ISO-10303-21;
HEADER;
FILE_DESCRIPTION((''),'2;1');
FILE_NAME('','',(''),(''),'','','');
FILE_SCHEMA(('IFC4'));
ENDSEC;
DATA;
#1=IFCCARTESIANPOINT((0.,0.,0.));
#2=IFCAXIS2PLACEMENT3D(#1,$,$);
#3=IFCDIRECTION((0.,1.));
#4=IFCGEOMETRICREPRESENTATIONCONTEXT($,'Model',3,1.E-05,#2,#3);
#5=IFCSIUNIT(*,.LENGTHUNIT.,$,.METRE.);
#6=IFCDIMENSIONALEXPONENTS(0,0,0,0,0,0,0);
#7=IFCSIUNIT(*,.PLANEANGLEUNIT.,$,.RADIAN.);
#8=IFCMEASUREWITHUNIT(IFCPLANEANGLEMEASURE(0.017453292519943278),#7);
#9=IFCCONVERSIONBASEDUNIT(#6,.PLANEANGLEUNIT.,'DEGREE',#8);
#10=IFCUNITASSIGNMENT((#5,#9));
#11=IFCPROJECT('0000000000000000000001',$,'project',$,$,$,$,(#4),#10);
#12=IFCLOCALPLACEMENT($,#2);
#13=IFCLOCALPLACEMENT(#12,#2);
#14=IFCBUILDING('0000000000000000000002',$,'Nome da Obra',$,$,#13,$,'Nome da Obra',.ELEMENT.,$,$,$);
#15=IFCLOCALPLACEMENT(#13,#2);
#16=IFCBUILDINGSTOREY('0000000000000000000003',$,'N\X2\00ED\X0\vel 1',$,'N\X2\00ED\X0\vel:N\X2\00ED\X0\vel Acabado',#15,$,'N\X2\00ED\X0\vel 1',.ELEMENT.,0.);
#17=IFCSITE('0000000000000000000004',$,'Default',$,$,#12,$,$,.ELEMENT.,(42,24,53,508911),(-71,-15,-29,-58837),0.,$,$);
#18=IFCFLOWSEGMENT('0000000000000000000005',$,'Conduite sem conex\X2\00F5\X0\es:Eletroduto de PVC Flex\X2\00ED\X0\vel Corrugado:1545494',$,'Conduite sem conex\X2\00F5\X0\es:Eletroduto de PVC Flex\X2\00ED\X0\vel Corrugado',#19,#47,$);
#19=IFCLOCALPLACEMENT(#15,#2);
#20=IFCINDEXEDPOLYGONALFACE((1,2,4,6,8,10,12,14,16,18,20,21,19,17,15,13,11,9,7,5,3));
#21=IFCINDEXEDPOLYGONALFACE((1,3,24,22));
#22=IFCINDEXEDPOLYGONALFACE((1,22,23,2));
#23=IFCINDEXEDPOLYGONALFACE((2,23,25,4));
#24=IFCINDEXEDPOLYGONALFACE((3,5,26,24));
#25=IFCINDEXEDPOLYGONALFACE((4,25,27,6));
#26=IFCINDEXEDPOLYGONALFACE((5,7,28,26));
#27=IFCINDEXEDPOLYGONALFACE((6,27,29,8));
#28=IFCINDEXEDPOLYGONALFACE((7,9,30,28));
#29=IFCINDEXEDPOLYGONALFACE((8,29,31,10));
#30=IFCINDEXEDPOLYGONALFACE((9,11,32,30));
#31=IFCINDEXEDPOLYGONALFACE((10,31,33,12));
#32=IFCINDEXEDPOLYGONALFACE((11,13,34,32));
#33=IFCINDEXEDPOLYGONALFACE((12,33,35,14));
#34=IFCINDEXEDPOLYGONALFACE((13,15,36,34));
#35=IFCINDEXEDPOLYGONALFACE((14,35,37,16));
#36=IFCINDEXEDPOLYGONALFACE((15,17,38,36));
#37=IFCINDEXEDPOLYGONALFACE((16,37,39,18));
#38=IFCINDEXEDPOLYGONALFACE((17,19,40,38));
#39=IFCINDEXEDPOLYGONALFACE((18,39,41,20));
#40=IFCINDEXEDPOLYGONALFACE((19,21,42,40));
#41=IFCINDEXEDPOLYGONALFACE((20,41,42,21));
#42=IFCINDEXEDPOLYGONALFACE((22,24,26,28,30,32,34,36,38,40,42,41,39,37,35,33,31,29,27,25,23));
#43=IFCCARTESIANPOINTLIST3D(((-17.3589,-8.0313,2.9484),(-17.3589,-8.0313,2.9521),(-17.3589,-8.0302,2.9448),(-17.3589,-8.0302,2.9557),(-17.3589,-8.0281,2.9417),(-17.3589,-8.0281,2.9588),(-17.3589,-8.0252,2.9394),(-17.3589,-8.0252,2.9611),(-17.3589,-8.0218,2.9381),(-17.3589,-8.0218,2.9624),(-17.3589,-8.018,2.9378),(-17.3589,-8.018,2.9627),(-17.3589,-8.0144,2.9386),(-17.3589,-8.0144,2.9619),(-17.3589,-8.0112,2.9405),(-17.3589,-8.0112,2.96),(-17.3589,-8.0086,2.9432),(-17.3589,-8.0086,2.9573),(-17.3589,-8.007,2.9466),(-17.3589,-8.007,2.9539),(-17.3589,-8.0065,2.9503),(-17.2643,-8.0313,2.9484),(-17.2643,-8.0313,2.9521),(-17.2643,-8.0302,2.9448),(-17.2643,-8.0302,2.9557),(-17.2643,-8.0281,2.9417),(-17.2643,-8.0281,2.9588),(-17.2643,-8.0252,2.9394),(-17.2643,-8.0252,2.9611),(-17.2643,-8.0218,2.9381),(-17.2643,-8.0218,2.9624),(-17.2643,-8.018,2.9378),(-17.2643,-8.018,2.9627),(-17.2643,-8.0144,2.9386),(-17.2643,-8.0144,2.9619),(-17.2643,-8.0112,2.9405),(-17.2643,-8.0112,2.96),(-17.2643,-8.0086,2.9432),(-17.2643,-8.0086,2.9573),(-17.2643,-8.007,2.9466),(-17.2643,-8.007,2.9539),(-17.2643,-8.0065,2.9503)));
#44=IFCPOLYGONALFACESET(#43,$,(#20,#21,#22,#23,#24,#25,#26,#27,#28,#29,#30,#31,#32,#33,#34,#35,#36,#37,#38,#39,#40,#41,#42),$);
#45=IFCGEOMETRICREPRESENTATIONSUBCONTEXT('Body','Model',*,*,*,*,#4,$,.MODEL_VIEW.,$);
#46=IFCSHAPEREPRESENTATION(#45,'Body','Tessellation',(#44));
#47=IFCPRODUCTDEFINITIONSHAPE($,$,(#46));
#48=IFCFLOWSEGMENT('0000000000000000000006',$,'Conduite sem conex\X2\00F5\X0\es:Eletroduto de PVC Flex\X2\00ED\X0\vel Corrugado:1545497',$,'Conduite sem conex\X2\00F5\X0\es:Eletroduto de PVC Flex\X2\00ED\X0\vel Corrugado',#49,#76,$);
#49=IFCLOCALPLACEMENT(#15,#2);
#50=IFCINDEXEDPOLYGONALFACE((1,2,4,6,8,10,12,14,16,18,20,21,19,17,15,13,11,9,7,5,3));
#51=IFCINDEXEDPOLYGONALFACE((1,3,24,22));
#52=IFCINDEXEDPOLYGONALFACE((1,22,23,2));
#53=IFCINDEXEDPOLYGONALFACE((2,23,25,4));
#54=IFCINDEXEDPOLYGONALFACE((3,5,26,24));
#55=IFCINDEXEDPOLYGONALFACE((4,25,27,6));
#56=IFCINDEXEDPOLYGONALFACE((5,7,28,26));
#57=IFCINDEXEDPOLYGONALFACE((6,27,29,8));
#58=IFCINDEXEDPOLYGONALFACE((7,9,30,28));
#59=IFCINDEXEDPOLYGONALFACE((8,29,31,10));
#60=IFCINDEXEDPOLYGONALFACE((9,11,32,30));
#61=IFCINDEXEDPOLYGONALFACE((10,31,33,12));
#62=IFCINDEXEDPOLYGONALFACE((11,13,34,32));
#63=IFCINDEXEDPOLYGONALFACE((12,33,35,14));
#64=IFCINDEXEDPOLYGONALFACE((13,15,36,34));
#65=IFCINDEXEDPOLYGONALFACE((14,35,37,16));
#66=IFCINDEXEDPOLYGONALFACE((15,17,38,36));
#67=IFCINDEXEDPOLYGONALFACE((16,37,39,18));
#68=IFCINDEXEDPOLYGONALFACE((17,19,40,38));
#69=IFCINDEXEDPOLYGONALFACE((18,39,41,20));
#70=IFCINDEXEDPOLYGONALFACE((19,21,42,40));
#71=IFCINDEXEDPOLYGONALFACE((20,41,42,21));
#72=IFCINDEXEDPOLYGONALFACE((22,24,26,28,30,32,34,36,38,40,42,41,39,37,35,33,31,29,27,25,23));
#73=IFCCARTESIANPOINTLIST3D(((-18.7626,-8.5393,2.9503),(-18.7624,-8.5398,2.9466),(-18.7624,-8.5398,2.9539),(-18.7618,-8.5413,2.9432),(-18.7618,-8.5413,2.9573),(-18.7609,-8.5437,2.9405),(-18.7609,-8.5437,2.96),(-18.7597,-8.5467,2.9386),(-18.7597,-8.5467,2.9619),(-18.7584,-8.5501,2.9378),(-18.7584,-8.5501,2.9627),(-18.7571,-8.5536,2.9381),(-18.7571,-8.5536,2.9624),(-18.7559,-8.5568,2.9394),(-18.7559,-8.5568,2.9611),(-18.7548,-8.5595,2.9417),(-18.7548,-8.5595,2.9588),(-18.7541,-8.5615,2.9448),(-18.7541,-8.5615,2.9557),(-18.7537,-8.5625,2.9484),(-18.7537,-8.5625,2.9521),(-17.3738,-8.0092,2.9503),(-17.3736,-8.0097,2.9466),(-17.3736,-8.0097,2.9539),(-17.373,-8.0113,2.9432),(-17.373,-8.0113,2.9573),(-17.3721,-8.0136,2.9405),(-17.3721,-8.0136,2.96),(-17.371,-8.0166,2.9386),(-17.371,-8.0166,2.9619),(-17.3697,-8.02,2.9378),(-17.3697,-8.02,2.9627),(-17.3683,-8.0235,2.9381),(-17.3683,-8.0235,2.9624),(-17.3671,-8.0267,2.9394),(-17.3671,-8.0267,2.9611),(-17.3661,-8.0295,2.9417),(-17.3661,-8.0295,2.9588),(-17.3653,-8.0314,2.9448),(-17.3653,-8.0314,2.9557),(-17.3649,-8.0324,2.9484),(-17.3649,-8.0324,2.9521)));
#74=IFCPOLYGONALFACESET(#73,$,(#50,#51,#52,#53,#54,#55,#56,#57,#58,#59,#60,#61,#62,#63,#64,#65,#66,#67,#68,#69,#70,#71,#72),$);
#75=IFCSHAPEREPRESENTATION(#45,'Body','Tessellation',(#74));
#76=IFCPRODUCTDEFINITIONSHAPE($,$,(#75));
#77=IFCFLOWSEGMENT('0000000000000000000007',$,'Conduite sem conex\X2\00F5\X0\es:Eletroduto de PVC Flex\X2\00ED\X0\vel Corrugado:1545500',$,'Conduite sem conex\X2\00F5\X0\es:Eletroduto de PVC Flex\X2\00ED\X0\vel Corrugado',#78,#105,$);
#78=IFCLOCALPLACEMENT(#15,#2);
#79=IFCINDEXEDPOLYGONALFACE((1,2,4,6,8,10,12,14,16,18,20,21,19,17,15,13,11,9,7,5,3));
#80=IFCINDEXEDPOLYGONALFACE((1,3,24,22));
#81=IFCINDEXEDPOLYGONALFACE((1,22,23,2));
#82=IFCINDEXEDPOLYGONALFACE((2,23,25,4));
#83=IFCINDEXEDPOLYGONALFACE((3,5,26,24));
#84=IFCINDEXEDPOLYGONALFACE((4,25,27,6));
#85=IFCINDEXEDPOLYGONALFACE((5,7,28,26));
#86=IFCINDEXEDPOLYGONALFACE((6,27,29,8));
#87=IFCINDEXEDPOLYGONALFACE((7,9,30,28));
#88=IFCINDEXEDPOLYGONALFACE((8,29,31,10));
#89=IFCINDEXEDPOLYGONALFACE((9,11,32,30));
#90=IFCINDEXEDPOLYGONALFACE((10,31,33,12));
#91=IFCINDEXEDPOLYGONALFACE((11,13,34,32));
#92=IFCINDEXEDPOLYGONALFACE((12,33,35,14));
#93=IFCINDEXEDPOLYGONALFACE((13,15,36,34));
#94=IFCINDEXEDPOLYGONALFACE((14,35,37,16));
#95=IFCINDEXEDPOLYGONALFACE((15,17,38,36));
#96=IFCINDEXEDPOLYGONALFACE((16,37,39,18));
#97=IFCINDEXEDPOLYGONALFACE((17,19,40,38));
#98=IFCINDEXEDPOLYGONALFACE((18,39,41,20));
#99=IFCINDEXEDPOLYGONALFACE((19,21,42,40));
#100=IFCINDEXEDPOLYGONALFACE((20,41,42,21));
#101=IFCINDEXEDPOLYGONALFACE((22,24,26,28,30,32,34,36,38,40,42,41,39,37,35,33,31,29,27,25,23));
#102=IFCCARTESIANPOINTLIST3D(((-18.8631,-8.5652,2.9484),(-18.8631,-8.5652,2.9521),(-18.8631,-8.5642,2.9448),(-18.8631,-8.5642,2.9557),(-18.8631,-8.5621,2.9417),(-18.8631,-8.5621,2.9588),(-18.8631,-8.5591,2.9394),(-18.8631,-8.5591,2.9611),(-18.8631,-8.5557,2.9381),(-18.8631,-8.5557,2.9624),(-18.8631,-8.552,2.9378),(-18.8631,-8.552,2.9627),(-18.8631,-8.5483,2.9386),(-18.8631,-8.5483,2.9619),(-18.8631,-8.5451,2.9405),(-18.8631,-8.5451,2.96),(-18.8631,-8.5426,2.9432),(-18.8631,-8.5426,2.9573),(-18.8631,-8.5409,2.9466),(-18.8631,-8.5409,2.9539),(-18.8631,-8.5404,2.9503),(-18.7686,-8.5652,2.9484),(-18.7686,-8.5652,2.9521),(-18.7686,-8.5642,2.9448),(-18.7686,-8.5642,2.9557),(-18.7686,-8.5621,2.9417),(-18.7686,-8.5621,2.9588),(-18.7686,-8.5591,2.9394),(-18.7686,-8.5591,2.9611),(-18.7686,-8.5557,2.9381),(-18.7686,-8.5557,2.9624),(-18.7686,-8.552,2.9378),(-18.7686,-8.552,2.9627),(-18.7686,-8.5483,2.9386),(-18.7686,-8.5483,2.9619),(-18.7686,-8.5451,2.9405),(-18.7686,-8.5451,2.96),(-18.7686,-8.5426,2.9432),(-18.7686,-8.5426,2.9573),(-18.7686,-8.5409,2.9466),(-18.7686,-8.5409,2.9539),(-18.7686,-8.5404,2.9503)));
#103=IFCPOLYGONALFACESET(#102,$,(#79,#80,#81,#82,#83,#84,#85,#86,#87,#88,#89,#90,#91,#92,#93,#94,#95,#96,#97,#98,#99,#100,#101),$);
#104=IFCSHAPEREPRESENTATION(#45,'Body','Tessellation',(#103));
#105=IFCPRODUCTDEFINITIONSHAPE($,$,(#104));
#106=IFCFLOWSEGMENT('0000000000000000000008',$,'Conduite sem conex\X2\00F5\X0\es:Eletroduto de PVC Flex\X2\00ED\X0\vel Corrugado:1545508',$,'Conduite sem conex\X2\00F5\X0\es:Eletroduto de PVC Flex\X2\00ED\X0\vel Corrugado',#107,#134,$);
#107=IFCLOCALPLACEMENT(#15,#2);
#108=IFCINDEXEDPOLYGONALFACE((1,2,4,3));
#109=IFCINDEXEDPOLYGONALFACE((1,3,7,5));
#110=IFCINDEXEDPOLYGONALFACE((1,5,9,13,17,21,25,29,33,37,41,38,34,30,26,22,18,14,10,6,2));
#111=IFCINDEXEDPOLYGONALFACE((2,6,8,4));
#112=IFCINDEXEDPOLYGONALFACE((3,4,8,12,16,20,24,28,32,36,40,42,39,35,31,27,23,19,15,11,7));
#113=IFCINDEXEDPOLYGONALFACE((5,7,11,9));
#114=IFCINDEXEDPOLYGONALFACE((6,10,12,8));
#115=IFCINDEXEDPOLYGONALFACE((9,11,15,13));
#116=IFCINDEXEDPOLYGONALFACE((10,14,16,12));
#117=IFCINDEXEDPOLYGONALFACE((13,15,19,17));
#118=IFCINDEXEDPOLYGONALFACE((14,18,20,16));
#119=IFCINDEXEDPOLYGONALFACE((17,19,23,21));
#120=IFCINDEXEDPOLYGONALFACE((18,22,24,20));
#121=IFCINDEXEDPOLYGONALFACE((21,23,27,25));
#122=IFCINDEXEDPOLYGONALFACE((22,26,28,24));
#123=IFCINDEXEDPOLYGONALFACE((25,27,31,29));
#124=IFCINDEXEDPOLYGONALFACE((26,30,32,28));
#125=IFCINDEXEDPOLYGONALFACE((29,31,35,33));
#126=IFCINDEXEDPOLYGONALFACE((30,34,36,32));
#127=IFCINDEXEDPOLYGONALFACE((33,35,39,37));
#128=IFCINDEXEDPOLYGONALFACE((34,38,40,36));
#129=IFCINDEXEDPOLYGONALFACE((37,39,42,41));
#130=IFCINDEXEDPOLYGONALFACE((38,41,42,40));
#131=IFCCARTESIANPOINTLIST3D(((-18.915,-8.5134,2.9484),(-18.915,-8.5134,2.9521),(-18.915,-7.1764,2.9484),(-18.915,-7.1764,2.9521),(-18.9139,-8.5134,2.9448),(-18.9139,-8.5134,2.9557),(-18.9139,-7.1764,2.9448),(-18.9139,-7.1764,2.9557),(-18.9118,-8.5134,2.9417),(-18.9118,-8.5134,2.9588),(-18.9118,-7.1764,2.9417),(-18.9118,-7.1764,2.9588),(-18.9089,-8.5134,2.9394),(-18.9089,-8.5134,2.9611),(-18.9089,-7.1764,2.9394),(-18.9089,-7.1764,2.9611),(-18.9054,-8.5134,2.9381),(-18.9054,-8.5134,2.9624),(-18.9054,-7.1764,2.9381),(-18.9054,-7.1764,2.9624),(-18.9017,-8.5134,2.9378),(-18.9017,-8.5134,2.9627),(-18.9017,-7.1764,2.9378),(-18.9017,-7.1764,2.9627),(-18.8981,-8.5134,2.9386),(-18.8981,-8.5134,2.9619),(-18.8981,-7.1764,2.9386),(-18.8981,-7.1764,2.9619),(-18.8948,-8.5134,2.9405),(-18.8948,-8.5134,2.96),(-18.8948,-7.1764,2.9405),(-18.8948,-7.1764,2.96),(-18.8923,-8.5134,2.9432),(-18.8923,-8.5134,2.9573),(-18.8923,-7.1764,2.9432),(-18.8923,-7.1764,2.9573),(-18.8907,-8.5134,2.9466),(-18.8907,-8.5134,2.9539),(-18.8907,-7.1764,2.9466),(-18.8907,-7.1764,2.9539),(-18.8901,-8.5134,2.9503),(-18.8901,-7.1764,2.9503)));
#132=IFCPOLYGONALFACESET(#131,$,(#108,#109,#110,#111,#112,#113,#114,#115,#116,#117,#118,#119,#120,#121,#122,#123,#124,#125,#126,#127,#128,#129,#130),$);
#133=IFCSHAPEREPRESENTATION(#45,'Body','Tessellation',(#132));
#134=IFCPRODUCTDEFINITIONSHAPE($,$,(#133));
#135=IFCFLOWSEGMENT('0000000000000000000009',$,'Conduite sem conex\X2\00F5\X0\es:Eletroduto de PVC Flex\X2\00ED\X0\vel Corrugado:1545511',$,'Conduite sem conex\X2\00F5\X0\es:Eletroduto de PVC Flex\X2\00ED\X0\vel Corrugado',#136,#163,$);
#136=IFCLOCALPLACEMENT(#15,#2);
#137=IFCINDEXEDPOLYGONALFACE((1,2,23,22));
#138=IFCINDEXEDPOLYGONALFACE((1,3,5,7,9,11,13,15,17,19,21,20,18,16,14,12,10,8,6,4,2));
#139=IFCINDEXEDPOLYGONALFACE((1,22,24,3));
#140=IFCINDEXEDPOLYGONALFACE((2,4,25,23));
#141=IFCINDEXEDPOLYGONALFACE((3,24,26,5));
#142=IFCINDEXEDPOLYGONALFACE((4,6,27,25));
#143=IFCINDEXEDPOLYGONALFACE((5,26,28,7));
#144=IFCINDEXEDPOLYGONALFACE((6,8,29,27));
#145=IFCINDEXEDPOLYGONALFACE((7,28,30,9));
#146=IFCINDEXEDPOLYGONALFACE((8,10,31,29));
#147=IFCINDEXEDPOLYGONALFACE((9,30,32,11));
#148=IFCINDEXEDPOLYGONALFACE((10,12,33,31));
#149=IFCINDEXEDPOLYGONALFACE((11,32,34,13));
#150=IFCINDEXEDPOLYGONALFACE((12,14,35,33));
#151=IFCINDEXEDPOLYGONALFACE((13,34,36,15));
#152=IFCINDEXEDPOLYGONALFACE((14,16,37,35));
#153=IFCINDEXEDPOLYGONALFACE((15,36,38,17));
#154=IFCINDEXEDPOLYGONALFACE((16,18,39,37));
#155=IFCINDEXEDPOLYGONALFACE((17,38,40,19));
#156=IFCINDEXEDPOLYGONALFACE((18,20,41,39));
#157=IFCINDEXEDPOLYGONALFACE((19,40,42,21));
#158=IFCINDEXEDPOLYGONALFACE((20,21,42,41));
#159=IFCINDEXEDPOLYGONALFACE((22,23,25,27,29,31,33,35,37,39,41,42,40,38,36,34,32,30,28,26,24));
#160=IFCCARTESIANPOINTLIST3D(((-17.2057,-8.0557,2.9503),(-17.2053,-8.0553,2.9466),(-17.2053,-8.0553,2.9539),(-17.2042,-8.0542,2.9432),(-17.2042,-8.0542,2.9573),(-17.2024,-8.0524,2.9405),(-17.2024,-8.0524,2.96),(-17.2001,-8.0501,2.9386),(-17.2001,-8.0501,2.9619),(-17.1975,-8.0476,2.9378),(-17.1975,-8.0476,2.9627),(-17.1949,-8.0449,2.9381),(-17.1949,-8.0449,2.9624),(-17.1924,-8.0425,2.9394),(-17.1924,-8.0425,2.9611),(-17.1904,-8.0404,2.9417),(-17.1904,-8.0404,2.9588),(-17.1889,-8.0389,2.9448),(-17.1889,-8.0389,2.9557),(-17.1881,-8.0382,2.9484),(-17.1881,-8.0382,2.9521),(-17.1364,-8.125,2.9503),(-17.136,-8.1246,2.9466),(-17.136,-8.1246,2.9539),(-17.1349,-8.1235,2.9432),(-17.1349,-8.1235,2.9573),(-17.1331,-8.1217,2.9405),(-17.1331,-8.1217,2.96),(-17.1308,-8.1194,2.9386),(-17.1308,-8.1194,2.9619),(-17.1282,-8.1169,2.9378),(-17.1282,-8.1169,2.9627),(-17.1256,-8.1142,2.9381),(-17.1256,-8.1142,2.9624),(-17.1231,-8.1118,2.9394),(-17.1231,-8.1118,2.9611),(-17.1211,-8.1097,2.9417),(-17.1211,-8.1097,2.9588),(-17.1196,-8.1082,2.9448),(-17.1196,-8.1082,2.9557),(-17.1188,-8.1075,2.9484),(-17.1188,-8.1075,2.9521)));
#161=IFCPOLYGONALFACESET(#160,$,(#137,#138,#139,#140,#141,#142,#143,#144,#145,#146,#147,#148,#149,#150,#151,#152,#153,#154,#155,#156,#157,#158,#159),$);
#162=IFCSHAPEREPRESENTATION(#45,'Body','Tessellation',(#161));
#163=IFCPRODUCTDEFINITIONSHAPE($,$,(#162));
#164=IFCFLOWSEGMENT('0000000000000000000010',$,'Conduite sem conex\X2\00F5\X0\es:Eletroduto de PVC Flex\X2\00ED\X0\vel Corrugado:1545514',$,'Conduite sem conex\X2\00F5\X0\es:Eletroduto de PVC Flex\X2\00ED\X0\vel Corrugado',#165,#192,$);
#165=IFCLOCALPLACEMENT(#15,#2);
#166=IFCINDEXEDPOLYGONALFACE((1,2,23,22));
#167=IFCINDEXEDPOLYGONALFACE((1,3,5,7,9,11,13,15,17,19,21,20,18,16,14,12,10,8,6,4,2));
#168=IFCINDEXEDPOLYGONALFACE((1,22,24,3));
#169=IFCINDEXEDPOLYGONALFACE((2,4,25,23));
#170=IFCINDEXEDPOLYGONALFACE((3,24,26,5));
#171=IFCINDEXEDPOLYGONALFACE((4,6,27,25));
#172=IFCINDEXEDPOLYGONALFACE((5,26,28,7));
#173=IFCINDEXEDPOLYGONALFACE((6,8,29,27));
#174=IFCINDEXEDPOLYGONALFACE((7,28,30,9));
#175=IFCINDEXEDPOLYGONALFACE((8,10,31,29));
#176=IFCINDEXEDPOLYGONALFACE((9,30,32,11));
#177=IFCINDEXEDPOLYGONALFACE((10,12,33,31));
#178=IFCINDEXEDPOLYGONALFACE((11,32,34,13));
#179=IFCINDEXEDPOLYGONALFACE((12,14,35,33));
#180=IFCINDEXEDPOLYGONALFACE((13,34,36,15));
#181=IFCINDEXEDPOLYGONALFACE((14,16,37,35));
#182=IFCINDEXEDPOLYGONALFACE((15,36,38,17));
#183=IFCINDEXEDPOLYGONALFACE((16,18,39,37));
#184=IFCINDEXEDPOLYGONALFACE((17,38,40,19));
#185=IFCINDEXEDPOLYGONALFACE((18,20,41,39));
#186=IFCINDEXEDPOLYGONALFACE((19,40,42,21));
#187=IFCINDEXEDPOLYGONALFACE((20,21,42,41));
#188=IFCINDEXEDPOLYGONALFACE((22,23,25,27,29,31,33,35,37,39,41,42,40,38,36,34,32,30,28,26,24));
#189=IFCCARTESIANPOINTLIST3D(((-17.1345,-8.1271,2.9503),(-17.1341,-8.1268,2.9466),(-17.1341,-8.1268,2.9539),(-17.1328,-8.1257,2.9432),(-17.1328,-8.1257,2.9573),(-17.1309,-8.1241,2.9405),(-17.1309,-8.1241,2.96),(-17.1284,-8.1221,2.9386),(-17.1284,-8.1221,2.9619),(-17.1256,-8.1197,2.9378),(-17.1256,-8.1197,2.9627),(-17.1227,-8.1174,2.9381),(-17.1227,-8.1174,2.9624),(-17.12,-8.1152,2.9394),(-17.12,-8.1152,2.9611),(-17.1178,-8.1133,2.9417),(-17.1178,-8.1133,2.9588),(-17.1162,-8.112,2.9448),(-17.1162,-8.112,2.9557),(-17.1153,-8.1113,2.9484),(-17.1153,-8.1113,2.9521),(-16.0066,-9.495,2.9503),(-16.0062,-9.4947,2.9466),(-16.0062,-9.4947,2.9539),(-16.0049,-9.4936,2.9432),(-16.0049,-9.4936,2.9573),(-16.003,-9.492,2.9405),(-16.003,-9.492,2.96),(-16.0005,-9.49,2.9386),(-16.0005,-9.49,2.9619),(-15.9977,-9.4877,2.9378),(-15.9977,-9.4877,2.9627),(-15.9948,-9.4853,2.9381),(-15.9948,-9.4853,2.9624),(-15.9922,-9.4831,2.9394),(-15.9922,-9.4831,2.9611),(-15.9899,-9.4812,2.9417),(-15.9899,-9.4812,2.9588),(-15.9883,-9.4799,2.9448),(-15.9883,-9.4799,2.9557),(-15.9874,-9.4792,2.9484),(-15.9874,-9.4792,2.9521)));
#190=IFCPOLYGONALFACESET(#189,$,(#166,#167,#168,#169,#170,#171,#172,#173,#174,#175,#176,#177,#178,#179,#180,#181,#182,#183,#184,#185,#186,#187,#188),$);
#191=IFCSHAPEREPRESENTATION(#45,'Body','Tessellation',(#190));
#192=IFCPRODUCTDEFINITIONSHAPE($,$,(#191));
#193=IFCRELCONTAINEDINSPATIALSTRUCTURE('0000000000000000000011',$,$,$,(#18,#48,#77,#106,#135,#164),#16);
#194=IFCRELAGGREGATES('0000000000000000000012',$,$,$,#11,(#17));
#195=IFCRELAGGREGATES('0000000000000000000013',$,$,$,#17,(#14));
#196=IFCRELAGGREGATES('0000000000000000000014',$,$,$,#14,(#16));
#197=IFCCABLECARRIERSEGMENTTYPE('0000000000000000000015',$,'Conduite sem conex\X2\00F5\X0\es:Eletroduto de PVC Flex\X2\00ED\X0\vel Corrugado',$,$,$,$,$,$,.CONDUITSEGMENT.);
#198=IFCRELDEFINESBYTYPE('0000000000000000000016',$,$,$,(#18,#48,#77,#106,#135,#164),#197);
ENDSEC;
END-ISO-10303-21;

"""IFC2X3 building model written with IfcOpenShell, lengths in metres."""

from ifc_helpers import new_model, entity, si_unit, converted_unit, direction, frame, frame_2d, origin, origin_2d_with_axis, place, context, subcontext, project, spatial, circle, extrude, type_object, element, save


model = new_model("IFC2X3")

# Units and contexts
model_context = context("Model", 3, precision=1e-05, world=origin(), true_north=direction((0.0, 1.0)))
body_context = subcontext(model_context, "Body", "Model", "MODEL_VIEW")
ifc_project = project(units=[si_unit("LENGTHUNIT", "METRE"), converted_unit("PLANEANGLEUNIT", "DEGREE", entity("IfcPlaneAngleMeasure", 0.017453292519943278), si_unit("PLANEANGLEUNIT", "RADIAN"), dimensions=[0, 0, 0, 0, 0, 0, 0])], contexts=[model_context])

# Site, building, storey
site_placement = place(None, origin())
site = spatial("IfcSite", under=ifc_project, at=site_placement, Name="Default", CompositionType="ELEMENT", RefLatitude=(42, 24, 53, 508911), RefLongitude=(-71, -15, -29, -58837), RefElevation=0.0)
building_placement = place(site_placement, origin())
building = spatial("IfcBuilding", under=site, at=building_placement, Name="Nome da Obra", LongName="Nome da Obra", CompositionType="ELEMENT")
storey_placement = place(building_placement, origin())
storey = spatial("IfcBuildingStorey", under=building, at=storey_placement, Name="Nível 1", ObjectType="Nível:Nível Acabado", LongName="Nível 1", CompositionType="ELEMENT", Elevation=0.0)

# Flow segments
cable_carrier_segment_type = type_object("IfcCableCarrierSegmentType", Name="Conduite sem conexões:Eletroduto de PVC Flexível Corrugado", PredefinedType="CONDUITSEGMENT")
flow_segment_1_placement = place(storey_placement, origin())
element("IfcFlowSegment", 1, at=flow_segment_1_placement, inside=storey, type_object=cable_carrier_segment_type, Name="Conduite sem conexões:Eletroduto de PVC Flexível Corrugado:1545494", ObjectType="Conduite sem conexões:Eletroduto de PVC Flexível Corrugado", context=body_context, shape_type="SweptSolid", body=[
    extrude(circle(Radius=0.0125, at=origin_2d_with_axis()), frame((-17.3589, -8.019, 2.9503), z_axis=(1.0, 0.0, 0.0), x_axis=(0.0, 1.0, 0.0)), (0.0, 0.0, 1.0), 0.0946),
])
flow_segment_2_placement = place(storey_placement, origin())
element("IfcFlowSegment", 2, at=flow_segment_2_placement, inside=storey, type_object=cable_carrier_segment_type, Name="Conduite sem conexões:Eletroduto de PVC Flexível Corrugado:1545497", ObjectType="Conduite sem conexões:Eletroduto de PVC Flexível Corrugado", context=body_context, shape_type="SweptSolid", body=[
    extrude(circle(Radius=0.0125, at=origin_2d_with_axis()), frame((-18.7581, -8.551, 2.9503), z_axis=(0.934262, 0.356586, 0.0), x_axis=(-0.356586, 0.934262, 0.0)), (0.0, 0.0, 1.0), 1.4865),
])
flow_segment_3_placement = place(storey_placement, origin())
element("IfcFlowSegment", 3, at=flow_segment_3_placement, inside=storey, type_object=cable_carrier_segment_type, Name="Conduite sem conexões:Eletroduto de PVC Flexível Corrugado:1545500", ObjectType="Conduite sem conexões:Eletroduto de PVC Flexível Corrugado", context=body_context, shape_type="SweptSolid", body=[
    extrude(circle(Radius=0.0125, at=frame_2d((0.0, 0.0), x_axis=(1.0, 0.0))), frame((-18.8631, -8.5529, 2.9503), z_axis=(1.0, 0.0, 0.0), x_axis=(0.0, 1.0, 0.0)), (0.0, 0.0, 1.0), 0.0946),
])
flow_segment_4_placement = place(storey_placement, origin())
element("IfcFlowSegment", 4, at=flow_segment_4_placement, inside=storey, type_object=cable_carrier_segment_type, Name="Conduite sem conexões:Eletroduto de PVC Flexível Corrugado:1545508", ObjectType="Conduite sem conexões:Eletroduto de PVC Flexível Corrugado", context=body_context, shape_type="SweptSolid", body=[
    extrude(circle(Radius=0.0125, at=origin_2d_with_axis()), frame((-18.9026, -8.5134, 2.9503), z_axis=(0.0, 1.0, 0.0), x_axis=(1.0, 0.0, 0.0)), (0.0, 0.0, 1.0), 1.337),
])
flow_segment_5_placement = place(storey_placement, origin())
element("IfcFlowSegment", 5, at=flow_segment_5_placement, inside=storey, type_object=cable_carrier_segment_type, Name="Conduite sem conexões:Eletroduto de PVC Flexível Corrugado:1545511", ObjectType="Conduite sem conexões:Eletroduto de PVC Flexível Corrugado", context=body_context, shape_type="SweptSolid", body=[
    extrude(circle(Radius=0.0125, at=origin_2d_with_axis()), frame((-17.1276, -8.1162, 2.9503), z_axis=(-0.707107, 0.707107, 0.0), x_axis=(-0.707107, -0.707107, 0.0)), (0.0, 0.0, 1.0), 0.098),
])
flow_segment_6_placement = place(storey_placement, origin())
element("IfcFlowSegment", 6, at=flow_segment_6_placement, inside=storey, type_object=cable_carrier_segment_type, Name="Conduite sem conexões:Eletroduto de PVC Flexível Corrugado:1545514", ObjectType="Conduite sem conexões:Eletroduto de PVC Flexível Corrugado", context=body_context, shape_type="SweptSolid", body=[
    extrude(circle(Radius=0.0125, at=frame_2d((0.0, 0.0), x_axis=(1.0, 0.0))), frame((-17.1249, -8.1192, 2.9503), z_axis=(0.636167, -0.771551, 0.0), x_axis=(-0.771551, -0.636167, 0.0)), (0.0, 0.0, 1.0), 1.7729),
])

save(model, "model.ifc")
